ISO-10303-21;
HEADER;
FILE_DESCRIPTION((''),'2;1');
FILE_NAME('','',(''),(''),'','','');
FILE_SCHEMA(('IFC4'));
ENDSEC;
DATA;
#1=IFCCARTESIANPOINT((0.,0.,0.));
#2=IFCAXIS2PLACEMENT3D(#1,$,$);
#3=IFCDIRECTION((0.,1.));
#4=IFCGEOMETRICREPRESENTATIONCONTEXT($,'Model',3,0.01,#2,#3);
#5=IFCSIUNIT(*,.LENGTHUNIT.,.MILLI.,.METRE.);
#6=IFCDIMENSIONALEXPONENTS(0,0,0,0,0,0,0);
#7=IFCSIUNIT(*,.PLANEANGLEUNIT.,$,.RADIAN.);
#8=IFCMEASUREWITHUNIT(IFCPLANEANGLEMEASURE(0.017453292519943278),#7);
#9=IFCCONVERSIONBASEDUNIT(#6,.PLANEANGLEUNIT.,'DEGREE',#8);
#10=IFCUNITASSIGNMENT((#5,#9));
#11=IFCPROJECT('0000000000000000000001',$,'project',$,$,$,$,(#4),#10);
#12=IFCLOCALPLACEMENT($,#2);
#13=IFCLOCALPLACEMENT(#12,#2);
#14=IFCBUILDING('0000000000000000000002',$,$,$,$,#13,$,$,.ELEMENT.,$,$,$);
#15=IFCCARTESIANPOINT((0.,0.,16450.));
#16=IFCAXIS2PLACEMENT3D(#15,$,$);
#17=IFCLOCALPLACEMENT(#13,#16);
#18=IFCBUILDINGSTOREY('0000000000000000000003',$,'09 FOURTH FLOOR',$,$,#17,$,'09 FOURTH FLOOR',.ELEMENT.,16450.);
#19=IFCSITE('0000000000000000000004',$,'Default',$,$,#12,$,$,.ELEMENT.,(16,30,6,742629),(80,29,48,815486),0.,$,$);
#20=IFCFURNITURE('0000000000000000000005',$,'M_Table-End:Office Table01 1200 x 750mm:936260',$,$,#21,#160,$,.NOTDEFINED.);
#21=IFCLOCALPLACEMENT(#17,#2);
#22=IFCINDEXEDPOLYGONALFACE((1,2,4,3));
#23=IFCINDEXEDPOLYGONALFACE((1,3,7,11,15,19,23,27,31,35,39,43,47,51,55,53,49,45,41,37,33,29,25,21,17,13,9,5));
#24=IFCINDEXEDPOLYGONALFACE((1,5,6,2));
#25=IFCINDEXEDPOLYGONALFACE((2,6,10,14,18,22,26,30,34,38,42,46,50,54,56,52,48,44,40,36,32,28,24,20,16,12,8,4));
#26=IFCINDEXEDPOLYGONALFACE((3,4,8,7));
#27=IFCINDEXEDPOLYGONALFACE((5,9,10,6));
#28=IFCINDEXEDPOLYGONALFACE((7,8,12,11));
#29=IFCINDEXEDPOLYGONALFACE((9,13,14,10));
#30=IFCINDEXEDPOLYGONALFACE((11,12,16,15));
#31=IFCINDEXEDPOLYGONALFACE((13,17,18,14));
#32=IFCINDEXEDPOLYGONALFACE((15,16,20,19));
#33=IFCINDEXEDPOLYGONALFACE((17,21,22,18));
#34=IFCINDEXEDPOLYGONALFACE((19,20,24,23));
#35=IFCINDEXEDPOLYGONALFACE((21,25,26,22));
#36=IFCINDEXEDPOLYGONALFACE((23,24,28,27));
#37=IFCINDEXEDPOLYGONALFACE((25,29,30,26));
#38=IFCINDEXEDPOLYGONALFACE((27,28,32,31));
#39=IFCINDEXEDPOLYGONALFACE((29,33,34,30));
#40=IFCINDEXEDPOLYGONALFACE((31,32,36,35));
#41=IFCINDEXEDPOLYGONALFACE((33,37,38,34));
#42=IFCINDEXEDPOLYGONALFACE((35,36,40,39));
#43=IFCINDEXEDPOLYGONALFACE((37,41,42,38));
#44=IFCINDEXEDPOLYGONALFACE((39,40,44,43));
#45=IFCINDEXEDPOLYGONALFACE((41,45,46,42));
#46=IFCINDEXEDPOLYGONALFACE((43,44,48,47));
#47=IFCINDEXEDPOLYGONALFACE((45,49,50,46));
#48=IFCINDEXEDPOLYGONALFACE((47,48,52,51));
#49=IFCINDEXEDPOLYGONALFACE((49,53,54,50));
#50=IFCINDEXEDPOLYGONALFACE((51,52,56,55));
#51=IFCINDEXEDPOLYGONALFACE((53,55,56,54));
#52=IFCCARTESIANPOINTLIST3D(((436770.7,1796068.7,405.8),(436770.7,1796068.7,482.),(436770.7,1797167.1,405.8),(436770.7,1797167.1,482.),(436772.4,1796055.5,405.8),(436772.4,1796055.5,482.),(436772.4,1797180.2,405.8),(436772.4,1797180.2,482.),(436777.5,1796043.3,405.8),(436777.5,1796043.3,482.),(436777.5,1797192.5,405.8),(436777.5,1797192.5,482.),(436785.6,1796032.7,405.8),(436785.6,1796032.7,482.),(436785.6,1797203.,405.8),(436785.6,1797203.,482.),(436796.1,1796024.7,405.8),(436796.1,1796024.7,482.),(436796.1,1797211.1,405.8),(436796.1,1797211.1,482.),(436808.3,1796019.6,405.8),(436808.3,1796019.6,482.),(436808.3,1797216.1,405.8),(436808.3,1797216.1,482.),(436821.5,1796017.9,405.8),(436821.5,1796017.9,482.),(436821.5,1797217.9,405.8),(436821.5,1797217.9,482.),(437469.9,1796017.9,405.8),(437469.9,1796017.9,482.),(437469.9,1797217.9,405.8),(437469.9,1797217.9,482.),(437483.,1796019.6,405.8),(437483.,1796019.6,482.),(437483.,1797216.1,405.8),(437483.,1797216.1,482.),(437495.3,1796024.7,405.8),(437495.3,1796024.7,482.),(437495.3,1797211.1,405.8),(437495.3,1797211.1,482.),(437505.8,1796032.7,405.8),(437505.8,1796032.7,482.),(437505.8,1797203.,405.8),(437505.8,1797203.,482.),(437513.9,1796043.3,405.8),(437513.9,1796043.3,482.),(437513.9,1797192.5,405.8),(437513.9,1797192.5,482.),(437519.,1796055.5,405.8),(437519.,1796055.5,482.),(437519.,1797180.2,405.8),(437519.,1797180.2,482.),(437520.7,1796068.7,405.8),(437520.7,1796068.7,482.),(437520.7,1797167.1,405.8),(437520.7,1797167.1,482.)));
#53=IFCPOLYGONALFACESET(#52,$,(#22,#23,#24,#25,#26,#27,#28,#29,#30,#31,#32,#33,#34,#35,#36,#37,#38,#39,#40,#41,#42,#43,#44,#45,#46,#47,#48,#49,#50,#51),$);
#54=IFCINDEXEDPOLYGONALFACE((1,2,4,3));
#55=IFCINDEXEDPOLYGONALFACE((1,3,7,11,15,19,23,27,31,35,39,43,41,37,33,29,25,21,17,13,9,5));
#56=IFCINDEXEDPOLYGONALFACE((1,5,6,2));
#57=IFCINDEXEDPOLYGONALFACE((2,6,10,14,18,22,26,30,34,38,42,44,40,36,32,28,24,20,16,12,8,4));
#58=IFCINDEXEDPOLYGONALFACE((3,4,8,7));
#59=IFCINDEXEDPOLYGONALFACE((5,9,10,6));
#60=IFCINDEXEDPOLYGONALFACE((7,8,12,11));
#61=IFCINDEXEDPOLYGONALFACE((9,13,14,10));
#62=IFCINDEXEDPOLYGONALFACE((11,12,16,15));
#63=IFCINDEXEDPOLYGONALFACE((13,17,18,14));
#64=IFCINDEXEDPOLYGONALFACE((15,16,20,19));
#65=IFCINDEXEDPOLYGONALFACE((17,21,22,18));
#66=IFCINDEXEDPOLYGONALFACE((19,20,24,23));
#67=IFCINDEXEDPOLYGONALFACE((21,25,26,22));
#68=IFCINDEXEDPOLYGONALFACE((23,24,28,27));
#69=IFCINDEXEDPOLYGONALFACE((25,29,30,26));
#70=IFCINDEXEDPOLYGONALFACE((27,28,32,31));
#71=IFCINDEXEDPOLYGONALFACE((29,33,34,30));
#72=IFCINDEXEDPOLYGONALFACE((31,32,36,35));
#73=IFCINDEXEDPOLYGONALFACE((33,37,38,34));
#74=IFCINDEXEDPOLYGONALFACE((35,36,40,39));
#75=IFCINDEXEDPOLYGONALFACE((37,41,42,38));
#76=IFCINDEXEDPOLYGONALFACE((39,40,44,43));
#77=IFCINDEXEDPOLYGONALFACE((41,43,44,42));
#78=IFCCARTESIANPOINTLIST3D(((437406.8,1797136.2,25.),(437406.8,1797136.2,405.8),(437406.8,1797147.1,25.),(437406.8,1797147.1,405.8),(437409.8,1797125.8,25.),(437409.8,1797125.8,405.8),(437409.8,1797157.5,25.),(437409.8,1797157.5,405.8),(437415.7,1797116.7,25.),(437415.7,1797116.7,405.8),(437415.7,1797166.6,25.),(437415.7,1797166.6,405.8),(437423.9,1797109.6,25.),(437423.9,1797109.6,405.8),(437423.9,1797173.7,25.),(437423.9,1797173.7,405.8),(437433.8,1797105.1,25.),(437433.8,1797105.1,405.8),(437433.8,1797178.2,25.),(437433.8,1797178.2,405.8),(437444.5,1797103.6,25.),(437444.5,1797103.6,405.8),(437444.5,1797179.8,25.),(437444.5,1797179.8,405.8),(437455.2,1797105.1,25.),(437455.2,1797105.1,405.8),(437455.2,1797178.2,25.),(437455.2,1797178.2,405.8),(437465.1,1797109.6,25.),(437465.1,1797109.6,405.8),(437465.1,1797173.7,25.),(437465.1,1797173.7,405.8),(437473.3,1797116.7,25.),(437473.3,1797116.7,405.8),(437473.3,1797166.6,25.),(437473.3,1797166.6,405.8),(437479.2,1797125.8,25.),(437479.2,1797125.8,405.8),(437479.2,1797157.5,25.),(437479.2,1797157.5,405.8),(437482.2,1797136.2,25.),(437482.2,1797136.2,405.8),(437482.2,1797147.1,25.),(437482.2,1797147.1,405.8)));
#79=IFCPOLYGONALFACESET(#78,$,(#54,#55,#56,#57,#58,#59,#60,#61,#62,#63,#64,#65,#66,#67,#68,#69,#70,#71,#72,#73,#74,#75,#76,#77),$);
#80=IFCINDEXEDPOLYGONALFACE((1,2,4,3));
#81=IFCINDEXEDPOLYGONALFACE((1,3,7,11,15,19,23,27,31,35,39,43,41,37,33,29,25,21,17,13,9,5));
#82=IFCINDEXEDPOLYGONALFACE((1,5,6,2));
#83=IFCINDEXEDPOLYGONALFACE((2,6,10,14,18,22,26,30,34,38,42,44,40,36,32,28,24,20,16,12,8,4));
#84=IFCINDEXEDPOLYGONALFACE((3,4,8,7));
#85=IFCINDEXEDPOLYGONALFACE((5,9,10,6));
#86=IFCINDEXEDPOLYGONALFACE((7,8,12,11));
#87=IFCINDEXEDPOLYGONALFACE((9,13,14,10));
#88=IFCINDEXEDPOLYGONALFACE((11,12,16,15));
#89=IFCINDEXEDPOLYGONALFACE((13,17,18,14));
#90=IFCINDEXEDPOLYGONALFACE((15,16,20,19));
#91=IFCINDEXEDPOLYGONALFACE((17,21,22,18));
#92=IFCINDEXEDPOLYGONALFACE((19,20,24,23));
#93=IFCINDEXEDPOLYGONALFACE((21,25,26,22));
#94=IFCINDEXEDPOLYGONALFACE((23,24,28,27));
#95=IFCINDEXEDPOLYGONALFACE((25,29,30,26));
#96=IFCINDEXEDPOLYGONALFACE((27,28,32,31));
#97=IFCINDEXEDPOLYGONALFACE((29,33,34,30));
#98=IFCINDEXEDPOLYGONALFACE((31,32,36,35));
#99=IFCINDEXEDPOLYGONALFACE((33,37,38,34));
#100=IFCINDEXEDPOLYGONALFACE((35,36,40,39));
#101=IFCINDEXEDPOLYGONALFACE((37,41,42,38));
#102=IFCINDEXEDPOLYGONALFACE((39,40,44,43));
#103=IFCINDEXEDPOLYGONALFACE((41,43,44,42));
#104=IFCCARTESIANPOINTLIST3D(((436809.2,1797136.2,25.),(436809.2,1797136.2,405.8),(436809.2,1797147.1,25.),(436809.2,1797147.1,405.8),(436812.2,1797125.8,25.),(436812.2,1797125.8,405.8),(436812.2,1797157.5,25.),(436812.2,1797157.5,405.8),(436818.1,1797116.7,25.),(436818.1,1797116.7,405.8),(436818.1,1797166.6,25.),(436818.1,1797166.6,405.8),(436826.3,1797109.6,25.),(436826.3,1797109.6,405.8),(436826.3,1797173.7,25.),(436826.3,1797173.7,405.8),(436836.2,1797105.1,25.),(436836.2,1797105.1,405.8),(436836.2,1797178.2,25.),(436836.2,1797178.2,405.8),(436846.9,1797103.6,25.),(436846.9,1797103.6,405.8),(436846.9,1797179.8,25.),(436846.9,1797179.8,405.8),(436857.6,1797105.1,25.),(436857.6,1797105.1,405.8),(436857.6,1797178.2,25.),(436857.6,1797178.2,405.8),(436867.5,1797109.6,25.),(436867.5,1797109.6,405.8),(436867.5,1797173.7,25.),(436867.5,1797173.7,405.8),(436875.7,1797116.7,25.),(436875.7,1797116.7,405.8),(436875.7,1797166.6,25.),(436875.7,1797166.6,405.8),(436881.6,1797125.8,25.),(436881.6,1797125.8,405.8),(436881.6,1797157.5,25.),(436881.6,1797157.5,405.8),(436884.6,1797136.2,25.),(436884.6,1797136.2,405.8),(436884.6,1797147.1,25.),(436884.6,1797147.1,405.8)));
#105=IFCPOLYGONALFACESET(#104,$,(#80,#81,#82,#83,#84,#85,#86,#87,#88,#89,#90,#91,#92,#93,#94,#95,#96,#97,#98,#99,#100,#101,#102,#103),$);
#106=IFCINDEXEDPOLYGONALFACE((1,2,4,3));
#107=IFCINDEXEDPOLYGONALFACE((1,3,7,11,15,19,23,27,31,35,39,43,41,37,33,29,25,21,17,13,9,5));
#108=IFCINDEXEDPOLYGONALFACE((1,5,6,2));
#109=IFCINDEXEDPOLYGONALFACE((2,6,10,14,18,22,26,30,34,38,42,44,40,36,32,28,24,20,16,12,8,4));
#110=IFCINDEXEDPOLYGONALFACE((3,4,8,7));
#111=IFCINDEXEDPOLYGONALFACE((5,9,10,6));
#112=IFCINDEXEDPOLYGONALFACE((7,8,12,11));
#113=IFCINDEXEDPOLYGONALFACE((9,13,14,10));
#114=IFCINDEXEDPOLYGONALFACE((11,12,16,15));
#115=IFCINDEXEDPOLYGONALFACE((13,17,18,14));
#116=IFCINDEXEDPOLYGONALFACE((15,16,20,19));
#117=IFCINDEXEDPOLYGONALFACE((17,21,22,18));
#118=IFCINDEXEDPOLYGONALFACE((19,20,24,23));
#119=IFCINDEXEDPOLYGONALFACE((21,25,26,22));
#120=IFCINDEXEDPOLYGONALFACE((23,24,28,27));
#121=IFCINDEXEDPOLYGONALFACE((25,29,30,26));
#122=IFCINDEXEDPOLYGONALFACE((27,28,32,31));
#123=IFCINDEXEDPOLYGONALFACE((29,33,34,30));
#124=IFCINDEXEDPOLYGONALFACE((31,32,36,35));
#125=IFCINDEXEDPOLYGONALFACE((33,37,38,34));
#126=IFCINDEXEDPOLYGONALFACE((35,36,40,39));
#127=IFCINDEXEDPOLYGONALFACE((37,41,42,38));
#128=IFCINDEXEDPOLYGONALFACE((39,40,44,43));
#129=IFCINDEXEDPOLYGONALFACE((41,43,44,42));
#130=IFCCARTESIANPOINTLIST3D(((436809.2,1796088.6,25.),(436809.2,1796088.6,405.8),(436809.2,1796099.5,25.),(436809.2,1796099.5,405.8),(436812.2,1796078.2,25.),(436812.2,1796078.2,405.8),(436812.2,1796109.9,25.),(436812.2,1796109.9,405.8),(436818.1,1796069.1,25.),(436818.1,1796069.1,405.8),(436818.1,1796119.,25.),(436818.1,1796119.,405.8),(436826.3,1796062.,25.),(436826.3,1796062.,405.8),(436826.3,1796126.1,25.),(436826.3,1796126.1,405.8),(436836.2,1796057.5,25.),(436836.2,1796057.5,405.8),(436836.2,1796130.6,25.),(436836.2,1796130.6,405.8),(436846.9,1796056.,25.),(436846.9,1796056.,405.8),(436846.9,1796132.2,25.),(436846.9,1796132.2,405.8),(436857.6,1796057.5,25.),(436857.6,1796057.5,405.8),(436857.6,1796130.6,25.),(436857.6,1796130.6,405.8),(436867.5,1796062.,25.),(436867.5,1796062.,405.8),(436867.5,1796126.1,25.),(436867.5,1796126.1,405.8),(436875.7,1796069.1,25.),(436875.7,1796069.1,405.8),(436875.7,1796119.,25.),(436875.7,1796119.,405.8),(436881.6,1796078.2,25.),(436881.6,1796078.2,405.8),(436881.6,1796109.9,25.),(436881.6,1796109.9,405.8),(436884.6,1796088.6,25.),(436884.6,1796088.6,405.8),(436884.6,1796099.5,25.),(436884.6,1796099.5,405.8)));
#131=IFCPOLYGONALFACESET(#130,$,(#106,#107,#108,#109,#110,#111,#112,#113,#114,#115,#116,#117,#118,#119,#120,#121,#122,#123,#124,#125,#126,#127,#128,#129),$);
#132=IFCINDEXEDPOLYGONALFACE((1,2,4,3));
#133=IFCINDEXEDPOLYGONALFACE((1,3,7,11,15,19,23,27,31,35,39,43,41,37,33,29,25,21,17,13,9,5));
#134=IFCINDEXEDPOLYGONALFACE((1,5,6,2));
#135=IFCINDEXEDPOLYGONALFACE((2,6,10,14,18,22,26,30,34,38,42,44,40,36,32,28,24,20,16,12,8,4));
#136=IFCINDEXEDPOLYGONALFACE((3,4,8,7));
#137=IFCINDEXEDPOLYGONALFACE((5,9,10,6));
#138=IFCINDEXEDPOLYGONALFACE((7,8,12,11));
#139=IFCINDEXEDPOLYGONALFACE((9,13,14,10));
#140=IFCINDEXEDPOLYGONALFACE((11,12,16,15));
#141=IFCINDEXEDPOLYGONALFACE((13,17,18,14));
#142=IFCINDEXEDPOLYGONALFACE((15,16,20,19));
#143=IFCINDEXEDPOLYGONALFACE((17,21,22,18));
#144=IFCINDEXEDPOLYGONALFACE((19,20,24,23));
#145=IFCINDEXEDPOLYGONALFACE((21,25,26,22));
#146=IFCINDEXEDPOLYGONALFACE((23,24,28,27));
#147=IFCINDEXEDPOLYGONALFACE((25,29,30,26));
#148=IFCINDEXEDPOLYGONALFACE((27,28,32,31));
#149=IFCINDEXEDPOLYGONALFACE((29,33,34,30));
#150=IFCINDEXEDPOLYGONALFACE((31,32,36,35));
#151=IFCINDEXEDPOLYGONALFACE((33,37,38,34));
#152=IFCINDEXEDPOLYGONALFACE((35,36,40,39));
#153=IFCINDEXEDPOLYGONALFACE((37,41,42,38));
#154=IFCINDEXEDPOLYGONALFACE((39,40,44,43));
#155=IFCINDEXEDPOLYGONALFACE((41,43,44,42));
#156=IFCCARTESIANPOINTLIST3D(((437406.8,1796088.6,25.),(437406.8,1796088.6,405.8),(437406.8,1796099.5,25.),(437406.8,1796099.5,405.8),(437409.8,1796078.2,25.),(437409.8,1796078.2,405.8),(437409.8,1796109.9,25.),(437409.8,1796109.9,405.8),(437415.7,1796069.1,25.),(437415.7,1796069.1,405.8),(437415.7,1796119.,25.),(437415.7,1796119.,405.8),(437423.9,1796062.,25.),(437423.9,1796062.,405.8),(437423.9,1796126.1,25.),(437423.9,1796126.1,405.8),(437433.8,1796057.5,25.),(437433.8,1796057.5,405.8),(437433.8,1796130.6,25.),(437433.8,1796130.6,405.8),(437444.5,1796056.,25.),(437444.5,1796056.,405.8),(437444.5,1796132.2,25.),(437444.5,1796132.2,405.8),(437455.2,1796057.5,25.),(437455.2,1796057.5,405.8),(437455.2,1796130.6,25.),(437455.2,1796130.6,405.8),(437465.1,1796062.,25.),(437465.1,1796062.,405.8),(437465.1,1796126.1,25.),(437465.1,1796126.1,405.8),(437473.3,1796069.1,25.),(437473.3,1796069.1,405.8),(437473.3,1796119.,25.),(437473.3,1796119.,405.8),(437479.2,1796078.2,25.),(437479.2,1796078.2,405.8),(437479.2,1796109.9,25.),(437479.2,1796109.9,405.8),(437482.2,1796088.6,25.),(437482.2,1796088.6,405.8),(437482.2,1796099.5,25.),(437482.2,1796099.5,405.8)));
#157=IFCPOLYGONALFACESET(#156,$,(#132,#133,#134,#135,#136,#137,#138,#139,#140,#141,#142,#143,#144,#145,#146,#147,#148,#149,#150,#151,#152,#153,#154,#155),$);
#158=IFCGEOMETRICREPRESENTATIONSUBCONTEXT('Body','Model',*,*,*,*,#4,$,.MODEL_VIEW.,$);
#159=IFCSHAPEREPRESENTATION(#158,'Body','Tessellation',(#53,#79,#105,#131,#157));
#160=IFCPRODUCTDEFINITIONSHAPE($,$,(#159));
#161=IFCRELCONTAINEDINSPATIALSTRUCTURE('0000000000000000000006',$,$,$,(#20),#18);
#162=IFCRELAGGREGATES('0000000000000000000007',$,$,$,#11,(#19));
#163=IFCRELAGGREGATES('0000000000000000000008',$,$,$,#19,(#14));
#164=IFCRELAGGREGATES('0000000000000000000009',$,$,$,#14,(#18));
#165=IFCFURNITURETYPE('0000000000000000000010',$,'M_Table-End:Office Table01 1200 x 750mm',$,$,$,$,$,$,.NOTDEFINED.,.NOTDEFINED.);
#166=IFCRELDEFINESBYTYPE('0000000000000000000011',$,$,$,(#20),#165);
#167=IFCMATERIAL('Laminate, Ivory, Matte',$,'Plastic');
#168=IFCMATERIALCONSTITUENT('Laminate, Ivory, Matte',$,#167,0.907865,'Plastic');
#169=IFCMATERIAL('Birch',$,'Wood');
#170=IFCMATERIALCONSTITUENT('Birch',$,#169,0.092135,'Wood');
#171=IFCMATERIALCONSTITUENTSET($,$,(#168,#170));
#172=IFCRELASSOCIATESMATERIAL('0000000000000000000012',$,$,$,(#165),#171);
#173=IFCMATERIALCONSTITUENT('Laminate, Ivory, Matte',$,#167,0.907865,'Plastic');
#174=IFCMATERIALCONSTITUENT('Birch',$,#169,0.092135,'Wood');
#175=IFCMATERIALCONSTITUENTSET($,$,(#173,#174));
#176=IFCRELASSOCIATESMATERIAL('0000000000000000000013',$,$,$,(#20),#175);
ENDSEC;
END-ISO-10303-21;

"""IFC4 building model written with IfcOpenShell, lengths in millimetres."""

from ifc_helpers import new_model, entity, si_unit, converted_unit, direction, frame, origin, place, context, subcontext, project, spatial, line, arc, indexed_curve, outline, extrude, source, transform, mapped, material, constituent, constituent_set, type_object, type_shapes, element, save


model = new_model("IFC4")

# Units and contexts
model_context = context("Model", 3, precision=0.01, world=origin(), true_north=direction((0.0, 1.0)))
body_context = subcontext(model_context, "Body", "Model", "MODEL_VIEW")
ifc_project = project(units=[si_unit("LENGTHUNIT", "METRE", prefix="MILLI"), converted_unit("PLANEANGLEUNIT", "DEGREE", entity("IfcPlaneAngleMeasure", 0.017453292519943278), si_unit("PLANEANGLEUNIT", "RADIAN"), dimensions=[0, 0, 0, 0, 0, 0, 0])], contexts=[model_context])

# Site, building, storey
site_placement = place(None, origin())
site = spatial("IfcSite", under=ifc_project, at=site_placement, Name="Default", CompositionType="ELEMENT", RefLatitude=(16, 30, 6, 742629), RefLongitude=(80, 29, 48, 815486), RefElevation=0.0)
building_placement = place(site_placement, origin())
building = spatial("IfcBuilding", under=site, at=building_placement, CompositionType="ELEMENT")
storey_placement = place(building_placement, frame((0.0, 0.0, 16450.0)))
storey = spatial("IfcBuildingStorey", under=building, at=storey_placement, Name="09 FOURTH FLOOR", LongName="09 FOURTH FLOOR", CompositionType="ELEMENT", Elevation=16450.0)

# Furniture
ifc_material_1 = material(Name="Laminate, Ivory, Matte", Category="Plastic")
ifc_constituent_1 = constituent(ifc_material_1, Name="Laminate, Ivory, Matte", Category="Plastic", fraction=0.907865)
ifc_material_2 = material(Name="Birch", Category="Wood")
ifc_constituent_2 = constituent(ifc_material_2, Name="Birch", Category="Wood", fraction=0.092135)
ifc_constituent_set_1 = constituent_set(constituents=[ifc_constituent_1, ifc_constituent_2])
ifc_constituent_3 = constituent(ifc_material_1, Name="Laminate, Ivory, Matte", Category="Plastic", fraction=0.907865)
ifc_constituent_4 = constituent(ifc_material_2, Name="Birch", Category="Wood", fraction=0.092135)
ifc_constituent_set_2 = constituent_set(constituents=[ifc_constituent_3, ifc_constituent_4])
furniture_type_1 = type_object("IfcFurnitureType", Name="M_Table-End:Office Table01 1200 x 750mm", AssemblyPlace="NOTDEFINED", PredefinedType="NOTDEFINED", material=ifc_constituent_set_2)
shared_shape_1 = source(origin(), body_context, "Body", "SweptSolid", [
    extrude(outline(indexed_curve([(549.2, -375.0), (585.1, -360.1), (600.0, -324.2), (600.0, 324.2), (585.1, 360.1), (549.2, 375.0), (-549.2, 375.0), (-585.1, 360.1), (-600.0, 324.2), (-600.0, -324.2), (-585.1, -360.1), (-549.2, -375.0)], segments=[arc(1, 2, 3), line(3, 4), arc(4, 5, 6), line(6, 7), arc(7, 8, 9), line(9, 10), arc(10, 11, 12), line(12, 1)], self_intersect=False)), frame((603.7, 152.4, 405.8)), (0.0, 0.0, 1.0), 76.2),
    extrude(outline(indexed_curve([(-38.1, 0.0), (0.0, -38.1), (38.1, 0.0), (0.0, 38.1)], segments=[arc(1, 2, 3), arc(3, 4, 1)], self_intersect=False)), frame((1127.5, -146.4, 25.0)), (0.0, 0.0, 1.0), 380.8),
    extrude(outline(indexed_curve([(-38.1, 0.0), (0.0, -38.1), (38.1, 0.0), (0.0, 38.1)], segments=[arc(1, 2, 3), arc(3, 4, 1)], self_intersect=False)), frame((1127.5, 451.2, 25.0)), (0.0, 0.0, 1.0), 380.8),
    extrude(outline(indexed_curve([(-38.1, 0.0), (0.0, -38.1), (38.1, 0.0), (0.0, 38.1)], segments=[arc(1, 2, 3), arc(3, 4, 1)], self_intersect=False)), frame((79.9, 451.2, 25.0)), (0.0, 0.0, 1.0), 380.8),
    extrude(outline(indexed_curve([(-38.1, 0.0), (0.0, -38.1), (38.1, 0.0), (0.0, 38.1)], segments=[arc(1, 2, 3), arc(3, 4, 1)], self_intersect=False)), frame((79.9, -146.4, 25.0)), (0.0, 0.0, 1.0), 380.8),
])
type_shapes(furniture_type_1, [shared_shape_1])
furniture_1_placement = place(storey_placement, frame((437298.1, 1796014.1, 0.0), z_axis=(0.0, 0.0, 1.0), x_axis=(0.0, 1.0, 0.0)))
element("IfcFurniture", 1, at=furniture_1_placement, inside=storey, type_object=furniture_type_1, material=ifc_constituent_set_1, Name="M_Table-End:Office Table01 1200 x 750mm:936260", PredefinedType="NOTDEFINED", context=body_context, shape_type="MappedRepresentation", body=[
    mapped(shared_shape_1, transform((0.0, 0.0, 0.0), scale=1.0)),
])

save(model, "model.ifc")
